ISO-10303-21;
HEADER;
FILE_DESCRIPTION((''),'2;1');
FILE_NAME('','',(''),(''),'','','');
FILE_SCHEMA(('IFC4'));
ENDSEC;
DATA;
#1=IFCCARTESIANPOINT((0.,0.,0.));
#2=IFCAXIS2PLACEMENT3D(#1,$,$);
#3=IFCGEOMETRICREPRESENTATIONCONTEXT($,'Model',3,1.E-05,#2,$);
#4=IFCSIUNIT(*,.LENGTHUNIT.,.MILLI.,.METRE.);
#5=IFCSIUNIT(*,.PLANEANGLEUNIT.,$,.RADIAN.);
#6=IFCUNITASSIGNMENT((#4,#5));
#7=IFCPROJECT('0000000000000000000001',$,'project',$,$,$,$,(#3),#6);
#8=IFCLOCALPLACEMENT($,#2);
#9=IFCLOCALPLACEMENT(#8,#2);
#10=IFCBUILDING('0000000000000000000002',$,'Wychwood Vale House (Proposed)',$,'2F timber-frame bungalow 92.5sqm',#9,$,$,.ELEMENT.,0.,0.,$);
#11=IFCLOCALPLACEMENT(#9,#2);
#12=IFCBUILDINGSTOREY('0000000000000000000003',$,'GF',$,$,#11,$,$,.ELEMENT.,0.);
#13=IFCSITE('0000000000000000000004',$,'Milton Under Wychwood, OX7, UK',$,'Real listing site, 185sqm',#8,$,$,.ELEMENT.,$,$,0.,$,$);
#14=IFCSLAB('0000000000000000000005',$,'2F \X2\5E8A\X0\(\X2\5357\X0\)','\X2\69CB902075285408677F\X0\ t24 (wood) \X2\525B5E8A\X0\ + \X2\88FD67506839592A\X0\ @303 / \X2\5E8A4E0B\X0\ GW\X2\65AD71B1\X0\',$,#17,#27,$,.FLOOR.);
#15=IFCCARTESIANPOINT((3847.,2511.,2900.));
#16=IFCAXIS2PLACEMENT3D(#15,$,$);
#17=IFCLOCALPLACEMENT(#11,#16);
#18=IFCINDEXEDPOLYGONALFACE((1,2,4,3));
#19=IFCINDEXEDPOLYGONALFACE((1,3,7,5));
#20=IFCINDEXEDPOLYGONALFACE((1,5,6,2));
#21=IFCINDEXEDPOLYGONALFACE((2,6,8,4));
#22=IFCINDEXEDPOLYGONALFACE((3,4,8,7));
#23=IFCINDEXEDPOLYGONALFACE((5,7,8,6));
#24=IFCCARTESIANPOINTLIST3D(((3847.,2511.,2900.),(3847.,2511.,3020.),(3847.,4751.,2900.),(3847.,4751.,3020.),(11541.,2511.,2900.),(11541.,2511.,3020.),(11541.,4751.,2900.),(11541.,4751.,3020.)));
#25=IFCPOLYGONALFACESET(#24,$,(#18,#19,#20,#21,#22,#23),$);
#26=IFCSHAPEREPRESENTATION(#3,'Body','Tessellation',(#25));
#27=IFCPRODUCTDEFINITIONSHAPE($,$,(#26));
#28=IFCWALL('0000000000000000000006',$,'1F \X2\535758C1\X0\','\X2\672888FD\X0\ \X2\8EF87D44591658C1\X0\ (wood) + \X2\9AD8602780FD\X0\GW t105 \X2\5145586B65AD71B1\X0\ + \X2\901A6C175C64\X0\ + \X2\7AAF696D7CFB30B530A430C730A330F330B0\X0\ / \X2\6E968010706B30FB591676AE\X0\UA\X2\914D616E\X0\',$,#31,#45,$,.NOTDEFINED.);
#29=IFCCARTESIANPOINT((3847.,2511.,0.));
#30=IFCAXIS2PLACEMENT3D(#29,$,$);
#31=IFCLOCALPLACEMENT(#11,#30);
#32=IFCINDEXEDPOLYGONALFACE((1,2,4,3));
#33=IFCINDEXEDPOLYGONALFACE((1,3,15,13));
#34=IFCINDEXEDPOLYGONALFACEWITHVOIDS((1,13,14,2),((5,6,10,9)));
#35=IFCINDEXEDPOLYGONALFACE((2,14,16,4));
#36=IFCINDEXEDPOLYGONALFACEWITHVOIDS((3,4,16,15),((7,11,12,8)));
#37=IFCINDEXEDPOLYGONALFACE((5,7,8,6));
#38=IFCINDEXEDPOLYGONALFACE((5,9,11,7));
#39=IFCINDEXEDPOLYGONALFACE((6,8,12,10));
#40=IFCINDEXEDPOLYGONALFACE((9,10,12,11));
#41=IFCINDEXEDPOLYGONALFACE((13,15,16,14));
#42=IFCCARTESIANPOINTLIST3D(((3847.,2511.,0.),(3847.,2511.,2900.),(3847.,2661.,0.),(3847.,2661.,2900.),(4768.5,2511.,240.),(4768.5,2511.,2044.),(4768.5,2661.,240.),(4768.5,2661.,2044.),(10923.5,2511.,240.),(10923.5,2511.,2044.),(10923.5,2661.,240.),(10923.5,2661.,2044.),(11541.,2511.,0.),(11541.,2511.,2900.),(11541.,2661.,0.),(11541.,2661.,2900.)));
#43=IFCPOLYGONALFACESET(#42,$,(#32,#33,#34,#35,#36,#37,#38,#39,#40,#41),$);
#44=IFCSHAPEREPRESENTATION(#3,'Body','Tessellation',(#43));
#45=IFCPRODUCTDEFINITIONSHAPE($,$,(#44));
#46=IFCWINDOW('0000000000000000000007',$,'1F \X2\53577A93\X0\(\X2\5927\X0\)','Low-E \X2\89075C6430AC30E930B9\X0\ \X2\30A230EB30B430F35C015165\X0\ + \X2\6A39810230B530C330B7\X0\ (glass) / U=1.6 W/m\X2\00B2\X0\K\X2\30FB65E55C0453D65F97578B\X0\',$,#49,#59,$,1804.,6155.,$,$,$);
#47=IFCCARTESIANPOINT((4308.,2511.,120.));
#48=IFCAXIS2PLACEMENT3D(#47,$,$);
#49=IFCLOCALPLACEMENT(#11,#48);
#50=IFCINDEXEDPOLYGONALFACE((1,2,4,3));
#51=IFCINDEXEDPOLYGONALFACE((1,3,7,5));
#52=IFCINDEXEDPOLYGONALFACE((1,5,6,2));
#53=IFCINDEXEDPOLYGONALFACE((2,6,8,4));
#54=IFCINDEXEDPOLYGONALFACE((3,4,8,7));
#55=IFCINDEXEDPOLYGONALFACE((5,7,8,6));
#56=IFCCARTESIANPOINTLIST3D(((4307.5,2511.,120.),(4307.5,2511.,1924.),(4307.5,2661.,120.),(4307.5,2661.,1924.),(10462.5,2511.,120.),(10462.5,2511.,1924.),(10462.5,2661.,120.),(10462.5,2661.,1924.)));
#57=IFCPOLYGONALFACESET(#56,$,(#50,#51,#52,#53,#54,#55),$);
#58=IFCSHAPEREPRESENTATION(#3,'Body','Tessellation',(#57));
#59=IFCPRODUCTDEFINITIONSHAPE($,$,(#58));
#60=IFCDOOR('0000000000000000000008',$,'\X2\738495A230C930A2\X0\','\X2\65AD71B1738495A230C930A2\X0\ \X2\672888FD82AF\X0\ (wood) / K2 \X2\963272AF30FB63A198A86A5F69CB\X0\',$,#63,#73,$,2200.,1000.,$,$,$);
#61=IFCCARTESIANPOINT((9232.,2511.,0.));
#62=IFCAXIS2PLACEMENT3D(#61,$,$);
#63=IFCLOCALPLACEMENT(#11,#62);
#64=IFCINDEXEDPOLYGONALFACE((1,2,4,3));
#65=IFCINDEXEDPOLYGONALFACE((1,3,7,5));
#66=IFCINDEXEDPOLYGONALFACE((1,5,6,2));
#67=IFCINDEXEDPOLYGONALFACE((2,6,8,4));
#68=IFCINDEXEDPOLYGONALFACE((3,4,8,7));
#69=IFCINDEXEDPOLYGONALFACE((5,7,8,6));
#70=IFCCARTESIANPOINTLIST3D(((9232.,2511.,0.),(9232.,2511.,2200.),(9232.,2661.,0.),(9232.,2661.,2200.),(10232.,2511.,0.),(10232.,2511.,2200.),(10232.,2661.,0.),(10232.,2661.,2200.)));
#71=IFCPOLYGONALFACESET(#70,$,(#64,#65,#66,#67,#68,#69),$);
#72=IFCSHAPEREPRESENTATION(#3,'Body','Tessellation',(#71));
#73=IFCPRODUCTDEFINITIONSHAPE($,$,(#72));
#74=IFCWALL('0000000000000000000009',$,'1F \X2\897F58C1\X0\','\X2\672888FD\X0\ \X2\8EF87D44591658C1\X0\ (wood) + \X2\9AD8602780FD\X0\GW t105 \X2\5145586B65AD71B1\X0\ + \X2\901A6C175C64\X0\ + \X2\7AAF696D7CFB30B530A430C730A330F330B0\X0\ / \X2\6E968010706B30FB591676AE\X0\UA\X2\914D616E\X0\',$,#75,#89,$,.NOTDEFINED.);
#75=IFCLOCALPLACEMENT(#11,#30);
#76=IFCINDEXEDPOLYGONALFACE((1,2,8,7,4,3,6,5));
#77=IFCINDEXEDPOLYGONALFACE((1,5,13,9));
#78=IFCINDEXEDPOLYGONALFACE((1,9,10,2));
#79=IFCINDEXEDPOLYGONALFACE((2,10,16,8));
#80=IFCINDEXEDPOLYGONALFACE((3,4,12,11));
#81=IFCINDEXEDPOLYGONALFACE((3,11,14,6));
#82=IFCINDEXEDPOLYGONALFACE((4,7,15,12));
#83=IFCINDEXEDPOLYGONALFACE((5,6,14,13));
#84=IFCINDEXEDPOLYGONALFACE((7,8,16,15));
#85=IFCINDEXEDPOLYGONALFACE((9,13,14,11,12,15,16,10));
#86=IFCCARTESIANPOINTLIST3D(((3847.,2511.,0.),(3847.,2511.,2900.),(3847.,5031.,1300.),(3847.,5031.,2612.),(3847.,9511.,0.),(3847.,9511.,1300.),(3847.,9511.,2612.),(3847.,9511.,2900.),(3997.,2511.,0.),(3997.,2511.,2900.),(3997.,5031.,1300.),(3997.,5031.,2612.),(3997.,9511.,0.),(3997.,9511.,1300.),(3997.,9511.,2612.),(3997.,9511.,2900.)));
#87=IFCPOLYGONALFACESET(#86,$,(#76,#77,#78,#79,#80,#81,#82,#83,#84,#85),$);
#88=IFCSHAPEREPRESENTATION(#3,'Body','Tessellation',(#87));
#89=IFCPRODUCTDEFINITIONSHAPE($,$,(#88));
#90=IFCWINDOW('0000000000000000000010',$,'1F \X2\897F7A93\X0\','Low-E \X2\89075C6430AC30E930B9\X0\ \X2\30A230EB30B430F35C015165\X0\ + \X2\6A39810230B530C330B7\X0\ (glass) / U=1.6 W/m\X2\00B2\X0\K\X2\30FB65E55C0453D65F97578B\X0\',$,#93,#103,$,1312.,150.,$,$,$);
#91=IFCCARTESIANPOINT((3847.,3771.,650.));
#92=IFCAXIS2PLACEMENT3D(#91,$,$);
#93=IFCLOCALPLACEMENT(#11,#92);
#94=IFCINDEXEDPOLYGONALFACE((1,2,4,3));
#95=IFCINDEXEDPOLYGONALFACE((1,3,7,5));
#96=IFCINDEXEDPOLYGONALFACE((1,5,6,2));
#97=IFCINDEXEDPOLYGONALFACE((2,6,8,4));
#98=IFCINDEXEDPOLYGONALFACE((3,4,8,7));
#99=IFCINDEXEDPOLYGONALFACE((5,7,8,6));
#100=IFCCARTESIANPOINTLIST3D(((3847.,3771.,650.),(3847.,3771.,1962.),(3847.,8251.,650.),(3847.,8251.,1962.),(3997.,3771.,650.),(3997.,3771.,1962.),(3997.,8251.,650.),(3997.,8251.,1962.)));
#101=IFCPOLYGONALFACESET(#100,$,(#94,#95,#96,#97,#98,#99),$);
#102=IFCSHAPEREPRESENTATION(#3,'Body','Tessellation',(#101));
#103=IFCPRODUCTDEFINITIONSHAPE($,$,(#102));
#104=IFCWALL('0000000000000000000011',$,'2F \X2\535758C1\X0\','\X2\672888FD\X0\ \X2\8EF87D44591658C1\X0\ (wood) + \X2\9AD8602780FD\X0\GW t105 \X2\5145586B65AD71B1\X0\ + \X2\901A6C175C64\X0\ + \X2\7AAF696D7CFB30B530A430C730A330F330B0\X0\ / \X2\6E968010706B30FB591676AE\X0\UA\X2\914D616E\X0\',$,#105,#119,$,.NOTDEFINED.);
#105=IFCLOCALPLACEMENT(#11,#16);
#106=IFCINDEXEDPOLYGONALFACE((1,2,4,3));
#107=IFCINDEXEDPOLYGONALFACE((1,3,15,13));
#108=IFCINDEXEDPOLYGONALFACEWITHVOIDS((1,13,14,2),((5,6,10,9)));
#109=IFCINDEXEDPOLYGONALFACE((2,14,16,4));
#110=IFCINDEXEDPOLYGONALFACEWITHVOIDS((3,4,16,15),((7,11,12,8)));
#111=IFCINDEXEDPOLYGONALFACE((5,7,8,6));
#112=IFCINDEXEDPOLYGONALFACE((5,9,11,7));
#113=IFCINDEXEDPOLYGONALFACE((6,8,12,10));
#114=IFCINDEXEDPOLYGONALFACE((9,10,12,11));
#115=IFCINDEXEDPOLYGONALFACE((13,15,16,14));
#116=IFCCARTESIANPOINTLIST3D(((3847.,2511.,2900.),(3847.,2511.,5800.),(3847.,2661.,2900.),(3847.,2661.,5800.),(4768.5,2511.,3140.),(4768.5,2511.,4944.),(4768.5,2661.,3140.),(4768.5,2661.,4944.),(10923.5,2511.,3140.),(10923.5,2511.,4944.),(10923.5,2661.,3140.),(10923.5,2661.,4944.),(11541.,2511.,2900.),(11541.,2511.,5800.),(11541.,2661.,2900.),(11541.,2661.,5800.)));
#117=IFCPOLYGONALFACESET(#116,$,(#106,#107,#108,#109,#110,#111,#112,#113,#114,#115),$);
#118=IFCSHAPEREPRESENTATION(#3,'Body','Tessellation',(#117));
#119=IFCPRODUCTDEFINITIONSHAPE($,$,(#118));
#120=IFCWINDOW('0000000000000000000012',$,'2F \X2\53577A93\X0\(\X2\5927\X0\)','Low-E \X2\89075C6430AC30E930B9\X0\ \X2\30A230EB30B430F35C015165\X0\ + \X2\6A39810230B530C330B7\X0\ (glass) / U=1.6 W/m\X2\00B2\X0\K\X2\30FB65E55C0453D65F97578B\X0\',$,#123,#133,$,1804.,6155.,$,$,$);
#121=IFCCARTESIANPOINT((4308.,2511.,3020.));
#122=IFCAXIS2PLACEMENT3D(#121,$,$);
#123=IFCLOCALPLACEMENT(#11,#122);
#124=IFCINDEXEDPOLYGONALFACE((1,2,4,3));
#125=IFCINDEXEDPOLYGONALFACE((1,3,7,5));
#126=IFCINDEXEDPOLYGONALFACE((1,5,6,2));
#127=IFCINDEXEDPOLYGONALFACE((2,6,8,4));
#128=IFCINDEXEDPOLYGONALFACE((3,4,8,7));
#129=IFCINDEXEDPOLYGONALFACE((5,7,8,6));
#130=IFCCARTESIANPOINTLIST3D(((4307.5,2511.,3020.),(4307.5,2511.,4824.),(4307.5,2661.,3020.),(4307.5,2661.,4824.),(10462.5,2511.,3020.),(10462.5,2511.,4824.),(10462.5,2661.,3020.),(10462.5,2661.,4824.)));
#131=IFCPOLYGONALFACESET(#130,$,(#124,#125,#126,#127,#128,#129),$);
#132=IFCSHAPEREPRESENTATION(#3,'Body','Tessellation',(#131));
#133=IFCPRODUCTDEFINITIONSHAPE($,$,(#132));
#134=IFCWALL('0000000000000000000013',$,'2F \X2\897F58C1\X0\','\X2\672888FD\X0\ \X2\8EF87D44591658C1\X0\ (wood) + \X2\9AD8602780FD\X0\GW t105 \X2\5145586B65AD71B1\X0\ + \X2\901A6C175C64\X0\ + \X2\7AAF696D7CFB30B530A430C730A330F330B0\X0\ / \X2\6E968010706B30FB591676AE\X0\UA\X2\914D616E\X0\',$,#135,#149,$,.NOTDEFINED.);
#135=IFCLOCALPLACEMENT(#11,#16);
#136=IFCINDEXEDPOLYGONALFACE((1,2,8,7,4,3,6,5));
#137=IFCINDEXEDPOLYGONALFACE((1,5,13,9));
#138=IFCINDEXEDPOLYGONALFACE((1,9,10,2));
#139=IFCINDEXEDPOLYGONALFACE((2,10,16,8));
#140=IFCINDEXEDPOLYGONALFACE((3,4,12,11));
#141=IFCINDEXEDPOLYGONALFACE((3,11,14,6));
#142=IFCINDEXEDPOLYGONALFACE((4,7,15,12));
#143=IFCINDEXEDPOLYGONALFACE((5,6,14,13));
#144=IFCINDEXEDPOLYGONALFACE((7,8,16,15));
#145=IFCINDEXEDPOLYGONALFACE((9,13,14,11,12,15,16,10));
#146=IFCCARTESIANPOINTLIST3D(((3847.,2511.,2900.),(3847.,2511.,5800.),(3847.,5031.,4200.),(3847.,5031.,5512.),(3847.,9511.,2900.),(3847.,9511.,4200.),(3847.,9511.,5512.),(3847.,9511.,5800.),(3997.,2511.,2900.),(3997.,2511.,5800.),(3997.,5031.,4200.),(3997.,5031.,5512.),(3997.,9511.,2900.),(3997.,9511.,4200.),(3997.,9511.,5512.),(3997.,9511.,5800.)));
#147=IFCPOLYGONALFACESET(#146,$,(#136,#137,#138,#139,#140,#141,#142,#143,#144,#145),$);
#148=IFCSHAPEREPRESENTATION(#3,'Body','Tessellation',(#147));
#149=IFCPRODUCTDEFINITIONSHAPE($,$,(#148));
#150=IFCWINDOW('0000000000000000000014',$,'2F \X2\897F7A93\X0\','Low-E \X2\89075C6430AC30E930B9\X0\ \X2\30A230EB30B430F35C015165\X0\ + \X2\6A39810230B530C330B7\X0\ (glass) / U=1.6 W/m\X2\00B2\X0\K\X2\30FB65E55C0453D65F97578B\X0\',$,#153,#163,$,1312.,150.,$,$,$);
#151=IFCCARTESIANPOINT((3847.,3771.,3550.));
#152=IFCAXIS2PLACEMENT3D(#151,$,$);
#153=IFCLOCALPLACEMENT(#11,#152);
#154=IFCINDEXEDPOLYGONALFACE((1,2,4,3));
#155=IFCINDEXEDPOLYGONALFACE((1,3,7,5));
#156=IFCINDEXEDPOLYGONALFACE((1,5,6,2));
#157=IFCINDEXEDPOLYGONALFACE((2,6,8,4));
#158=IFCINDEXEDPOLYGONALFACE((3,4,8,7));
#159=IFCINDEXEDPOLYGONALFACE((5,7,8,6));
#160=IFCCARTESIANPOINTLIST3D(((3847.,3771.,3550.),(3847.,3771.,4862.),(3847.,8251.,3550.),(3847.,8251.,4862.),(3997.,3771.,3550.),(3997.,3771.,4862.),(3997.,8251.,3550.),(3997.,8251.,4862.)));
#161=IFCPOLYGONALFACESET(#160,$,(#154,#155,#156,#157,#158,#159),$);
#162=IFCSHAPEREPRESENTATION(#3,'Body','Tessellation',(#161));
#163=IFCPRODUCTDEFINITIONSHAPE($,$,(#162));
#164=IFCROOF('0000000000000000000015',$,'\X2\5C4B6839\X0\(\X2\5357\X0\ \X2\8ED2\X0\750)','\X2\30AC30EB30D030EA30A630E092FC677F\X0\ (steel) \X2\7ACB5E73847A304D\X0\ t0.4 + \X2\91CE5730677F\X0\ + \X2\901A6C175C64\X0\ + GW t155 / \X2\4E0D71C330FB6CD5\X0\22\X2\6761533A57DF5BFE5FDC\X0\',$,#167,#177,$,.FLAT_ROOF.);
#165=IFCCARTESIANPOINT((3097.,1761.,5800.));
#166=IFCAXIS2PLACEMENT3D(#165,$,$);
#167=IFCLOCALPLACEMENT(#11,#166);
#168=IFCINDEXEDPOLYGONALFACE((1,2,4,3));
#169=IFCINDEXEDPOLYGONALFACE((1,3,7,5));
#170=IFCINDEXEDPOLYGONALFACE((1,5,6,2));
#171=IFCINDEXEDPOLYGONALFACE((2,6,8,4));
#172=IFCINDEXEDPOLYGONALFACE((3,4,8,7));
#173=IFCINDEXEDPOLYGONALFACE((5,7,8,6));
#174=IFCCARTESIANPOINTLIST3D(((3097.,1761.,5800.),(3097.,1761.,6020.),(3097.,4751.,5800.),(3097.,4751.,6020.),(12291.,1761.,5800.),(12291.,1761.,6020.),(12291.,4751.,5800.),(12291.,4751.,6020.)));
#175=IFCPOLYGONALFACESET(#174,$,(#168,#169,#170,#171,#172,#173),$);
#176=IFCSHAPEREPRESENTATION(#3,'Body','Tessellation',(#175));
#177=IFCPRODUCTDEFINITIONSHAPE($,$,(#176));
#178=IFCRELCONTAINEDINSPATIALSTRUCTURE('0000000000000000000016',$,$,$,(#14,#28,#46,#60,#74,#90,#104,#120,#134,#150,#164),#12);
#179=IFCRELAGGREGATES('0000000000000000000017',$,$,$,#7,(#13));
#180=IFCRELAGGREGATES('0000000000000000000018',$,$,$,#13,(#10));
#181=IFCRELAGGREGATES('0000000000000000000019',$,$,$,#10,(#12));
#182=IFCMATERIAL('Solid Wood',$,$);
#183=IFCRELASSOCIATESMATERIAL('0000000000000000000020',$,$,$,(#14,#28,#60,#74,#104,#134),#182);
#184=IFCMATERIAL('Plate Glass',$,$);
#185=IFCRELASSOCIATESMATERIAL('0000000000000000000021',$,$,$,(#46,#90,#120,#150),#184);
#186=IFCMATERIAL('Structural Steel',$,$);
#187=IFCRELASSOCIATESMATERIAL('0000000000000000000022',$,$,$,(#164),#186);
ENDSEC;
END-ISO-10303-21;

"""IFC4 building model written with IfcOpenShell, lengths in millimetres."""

from ifc_helpers import new_model, si_unit, frame, frame_2d, origin, place, context, project, spatial, rectangle, extrude, material, element, fill, save


model = new_model("IFC4")

# Units and contexts
model_context = context("Model", 3, precision=1e-05, world=origin())
ifc_project = project(units=[si_unit("LENGTHUNIT", "METRE", prefix="MILLI"), si_unit("PLANEANGLEUNIT", "RADIAN")], contexts=[model_context])

# Site, building, storey
site_placement = place(None, origin())
site = spatial("IfcSite", under=ifc_project, at=site_placement, Name="Milton Under Wychwood, OX7, UK", ObjectType="Real listing site, 185sqm", CompositionType="ELEMENT", RefElevation=0.0)
building_placement = place(site_placement, origin())
building = spatial("IfcBuilding", under=site, at=building_placement, Name="Wychwood Vale House (Proposed)", ObjectType="2F timber-frame bungalow 92.5sqm", CompositionType="ELEMENT", ElevationOfRefHeight=0.0, ElevationOfTerrain=0.0)
storey_placement = place(building_placement, origin())
storey = spatial("IfcBuildingStorey", under=building, at=storey_placement, Name="GF", CompositionType="ELEMENT", Elevation=0.0)

# Slab
ifc_material_1 = material(Name="Solid Wood")
slab_1_placement = place(storey_placement, frame((3847.0, 2511.0, 2900.0)))
element("IfcSlab", 1, at=slab_1_placement, inside=storey, material=ifc_material_1, Name="2F 床(南)", Description="構造用合板 t24 (wood) 剛床 + 製材根太 @303 / 床下 GW断熱", PredefinedType="FLOOR", context=model_context, shape_type="SweptSolid", body=[
    extrude(rectangle(XDim=7694.0, YDim=2240.0, at=frame_2d((3847.0, 1120.0))), frame((3847.0, 2511.0, 2900.0)), (0.0, 0.0, 1.0), 120.0),
])

# Wall, openings, window, door
wall_1_placement = place(storey_placement, frame((3847.0, 2511.0, 0.0)))
wall_1 = element("IfcWall", 2, at=wall_1_placement, inside=storey, material=ifc_material_1, Name="1F 南壁", Description="木製 軸組外壁 (wood) + 高性能GW t105 充填断熱 + 通気層 + 窯業系サイディング / 準耐火・外皮UA配慮", PredefinedType="NOTDEFINED", context=model_context, shape_type="SweptSolid", body=[
    extrude(rectangle(XDim=7694.0, YDim=150.0, at=frame_2d((3847.0, 75.0))), frame((3847.0, 2511.0, 0.0)), (0.0, 0.0, 1.0), 2900.0),
])
opening_1_placement = place(storey_placement, frame((4308.0, 2511.0, 120.0)))
opening_1 = element("IfcOpeningElement", 3, at=opening_1_placement, cuts=wall_1, PredefinedType="NOTDEFINED", context=model_context, shape_type="SweptSolid", body=[
    extrude(rectangle(XDim=6155.0, YDim=150.0, at=frame_2d((3077.0, 75.0))), frame((4308.0, 2511.0, 120.0)), (0.0, 0.0, 1.0), 1804.0),
])
opening_2_placement = place(storey_placement, frame((9232.0, 2511.0, 0.0)))
opening_2 = element("IfcOpeningElement", 4, at=opening_2_placement, cuts=wall_1, PredefinedType="NOTDEFINED", context=model_context, shape_type="SweptSolid", body=[
    extrude(rectangle(XDim=1000.0, YDim=150.0, at=frame_2d((500.0, 75.0))), frame((9232.0, 2511.0, 0.0)), (0.0, 0.0, 1.0), 2200.0),
])
ifc_material_2 = material(Name="Plate Glass")
window_1_placement = place(storey_placement, frame((4308.0, 2511.0, 120.0)))
window_1 = element("IfcWindow", 5, at=window_1_placement, inside=storey, material=ifc_material_2, Name="1F 南窓(大)", Description="Low-E 複層ガラス アルゴン封入 + 樹脂サッシ (glass) / U=1.6 W/m²K・日射取得型", OverallHeight=1804.0, OverallWidth=6155.0, context=model_context, shape_type="SweptSolid", body=[
    extrude(rectangle(XDim=6155.0, YDim=150.0, at=frame_2d((3077.0, 75.0))), frame((4308.0, 2511.0, 120.0)), (0.0, 0.0, 1.0), 1804.0),
])
fill(opening_1, window_1)
door_placement = place(storey_placement, frame((9232.0, 2511.0, 0.0)))
door = element("IfcDoor", 6, at=door_placement, inside=storey, material=ifc_material_1, Name="玄関ドア", Description="断熱玄関ドア 木製芯 (wood) / K2 防犯・採風機構", OverallHeight=2200.0, OverallWidth=1000.0, context=model_context, shape_type="SweptSolid", body=[
    extrude(rectangle(XDim=1000.0, YDim=150.0, at=frame_2d((500.0, 75.0))), frame((9232.0, 2511.0, 0.0)), (0.0, 0.0, 1.0), 2200.0),
])
fill(opening_2, door)

# Walls, openings, windows
wall_2_placement = place(storey_placement, frame((3847.0, 2511.0, 0.0)))
wall_2 = element("IfcWall", 7, at=wall_2_placement, inside=storey, material=ifc_material_1, Name="1F 西壁", Description="木製 軸組外壁 (wood) + 高性能GW t105 充填断熱 + 通気層 + 窯業系サイディング / 準耐火・外皮UA配慮", PredefinedType="NOTDEFINED", context=model_context, shape_type="SweptSolid", body=[
    extrude(rectangle(XDim=150.0, YDim=7000.0, at=frame_2d((75.0, 3500.0))), frame((3847.0, 2511.0, 0.0)), (0.0, 0.0, 1.0), 2900.0),
])
opening_3_placement = place(storey_placement, frame((3847.0, 3771.0, 650.0)))
opening_3 = element("IfcOpeningElement", 8, at=opening_3_placement, cuts=wall_2, PredefinedType="NOTDEFINED", context=model_context, shape_type="SweptSolid", body=[
    extrude(rectangle(XDim=150.0, YDim=4480.0, at=frame_2d((75.0, 2240.0))), frame((3847.0, 3771.0, 650.0)), (0.0, 0.0, 1.0), 1312.0),
])
window_2_placement = place(storey_placement, frame((3847.0, 3771.0, 650.0)))
window_2 = element("IfcWindow", 9, at=window_2_placement, inside=storey, material=ifc_material_2, Name="1F 西窓", Description="Low-E 複層ガラス アルゴン封入 + 樹脂サッシ (glass) / U=1.6 W/m²K・日射取得型", OverallHeight=1312.0, OverallWidth=150.0, context=model_context, shape_type="SweptSolid", body=[
    extrude(rectangle(XDim=150.0, YDim=4480.0, at=frame_2d((75.0, 2240.0))), frame((3847.0, 3771.0, 650.0)), (0.0, 0.0, 1.0), 1312.0),
])
fill(opening_3, window_2)
wall_3_placement = place(storey_placement, frame((3847.0, 2511.0, 2900.0)))
wall_3 = element("IfcWall", 10, at=wall_3_placement, inside=storey, material=ifc_material_1, Name="2F 南壁", Description="木製 軸組外壁 (wood) + 高性能GW t105 充填断熱 + 通気層 + 窯業系サイディング / 準耐火・外皮UA配慮", PredefinedType="NOTDEFINED", context=model_context, shape_type="SweptSolid", body=[
    extrude(rectangle(XDim=7694.0, YDim=150.0, at=frame_2d((3847.0, 75.0))), frame((3847.0, 2511.0, 2900.0)), (0.0, 0.0, 1.0), 2900.0),
])
opening_4_placement = place(storey_placement, frame((4308.0, 2511.0, 3020.0)))
opening_4 = element("IfcOpeningElement", 11, at=opening_4_placement, cuts=wall_3, PredefinedType="NOTDEFINED", context=model_context, shape_type="SweptSolid", body=[
    extrude(rectangle(XDim=6155.0, YDim=150.0, at=frame_2d((3077.0, 75.0))), frame((4308.0, 2511.0, 3020.0)), (0.0, 0.0, 1.0), 1804.0),
])
window_3_placement = place(storey_placement, frame((4308.0, 2511.0, 3020.0)))
window_3 = element("IfcWindow", 12, at=window_3_placement, inside=storey, material=ifc_material_2, Name="2F 南窓(大)", Description="Low-E 複層ガラス アルゴン封入 + 樹脂サッシ (glass) / U=1.6 W/m²K・日射取得型", OverallHeight=1804.0, OverallWidth=6155.0, context=model_context, shape_type="SweptSolid", body=[
    extrude(rectangle(XDim=6155.0, YDim=150.0, at=frame_2d((3077.0, 75.0))), frame((4308.0, 2511.0, 3020.0)), (0.0, 0.0, 1.0), 1804.0),
])
fill(opening_4, window_3)
wall_4_placement = place(storey_placement, frame((3847.0, 2511.0, 2900.0)))
wall_4 = element("IfcWall", 13, at=wall_4_placement, inside=storey, material=ifc_material_1, Name="2F 西壁", Description="木製 軸組外壁 (wood) + 高性能GW t105 充填断熱 + 通気層 + 窯業系サイディング / 準耐火・外皮UA配慮", PredefinedType="NOTDEFINED", context=model_context, shape_type="SweptSolid", body=[
    extrude(rectangle(XDim=150.0, YDim=7000.0, at=frame_2d((75.0, 3500.0))), frame((3847.0, 2511.0, 2900.0)), (0.0, 0.0, 1.0), 2900.0),
])
opening_5_placement = place(storey_placement, frame((3847.0, 3771.0, 3550.0)))
opening_5 = element("IfcOpeningElement", 14, at=opening_5_placement, cuts=wall_4, PredefinedType="NOTDEFINED", context=model_context, shape_type="SweptSolid", body=[
    extrude(rectangle(XDim=150.0, YDim=4480.0, at=frame_2d((75.0, 2240.0))), frame((3847.0, 3771.0, 3550.0)), (0.0, 0.0, 1.0), 1312.0),
])
window_4_placement = place(storey_placement, frame((3847.0, 3771.0, 3550.0)))
window_4 = element("IfcWindow", 15, at=window_4_placement, inside=storey, material=ifc_material_2, Name="2F 西窓", Description="Low-E 複層ガラス アルゴン封入 + 樹脂サッシ (glass) / U=1.6 W/m²K・日射取得型", OverallHeight=1312.0, OverallWidth=150.0, context=model_context, shape_type="SweptSolid", body=[
    extrude(rectangle(XDim=150.0, YDim=4480.0, at=frame_2d((75.0, 2240.0))), frame((3847.0, 3771.0, 3550.0)), (0.0, 0.0, 1.0), 1312.0),
])
fill(opening_5, window_4)

# Roof
ifc_material_3 = material(Name="Structural Steel")
roof_1_placement = place(storey_placement, frame((3097.0, 1761.0, 5800.0)))
element("IfcRoof", 16, at=roof_1_placement, inside=storey, material=ifc_material_3, Name="屋根(南 軒750)", Description="ガルバリウム鋼板 (steel) 立平葺き t0.4 + 野地板 + 通気層 + GW t155 / 不燃・法22条区域対応", PredefinedType="FLAT_ROOF", context=model_context, shape_type="SweptSolid", body=[
    extrude(rectangle(XDim=9194.0, YDim=2990.0, at=frame_2d((4597.0, 1495.0))), frame((3097.0, 1761.0, 5800.0)), (0.0, 0.0, 1.0), 220.0),
])

save(model, "model.ifc")
